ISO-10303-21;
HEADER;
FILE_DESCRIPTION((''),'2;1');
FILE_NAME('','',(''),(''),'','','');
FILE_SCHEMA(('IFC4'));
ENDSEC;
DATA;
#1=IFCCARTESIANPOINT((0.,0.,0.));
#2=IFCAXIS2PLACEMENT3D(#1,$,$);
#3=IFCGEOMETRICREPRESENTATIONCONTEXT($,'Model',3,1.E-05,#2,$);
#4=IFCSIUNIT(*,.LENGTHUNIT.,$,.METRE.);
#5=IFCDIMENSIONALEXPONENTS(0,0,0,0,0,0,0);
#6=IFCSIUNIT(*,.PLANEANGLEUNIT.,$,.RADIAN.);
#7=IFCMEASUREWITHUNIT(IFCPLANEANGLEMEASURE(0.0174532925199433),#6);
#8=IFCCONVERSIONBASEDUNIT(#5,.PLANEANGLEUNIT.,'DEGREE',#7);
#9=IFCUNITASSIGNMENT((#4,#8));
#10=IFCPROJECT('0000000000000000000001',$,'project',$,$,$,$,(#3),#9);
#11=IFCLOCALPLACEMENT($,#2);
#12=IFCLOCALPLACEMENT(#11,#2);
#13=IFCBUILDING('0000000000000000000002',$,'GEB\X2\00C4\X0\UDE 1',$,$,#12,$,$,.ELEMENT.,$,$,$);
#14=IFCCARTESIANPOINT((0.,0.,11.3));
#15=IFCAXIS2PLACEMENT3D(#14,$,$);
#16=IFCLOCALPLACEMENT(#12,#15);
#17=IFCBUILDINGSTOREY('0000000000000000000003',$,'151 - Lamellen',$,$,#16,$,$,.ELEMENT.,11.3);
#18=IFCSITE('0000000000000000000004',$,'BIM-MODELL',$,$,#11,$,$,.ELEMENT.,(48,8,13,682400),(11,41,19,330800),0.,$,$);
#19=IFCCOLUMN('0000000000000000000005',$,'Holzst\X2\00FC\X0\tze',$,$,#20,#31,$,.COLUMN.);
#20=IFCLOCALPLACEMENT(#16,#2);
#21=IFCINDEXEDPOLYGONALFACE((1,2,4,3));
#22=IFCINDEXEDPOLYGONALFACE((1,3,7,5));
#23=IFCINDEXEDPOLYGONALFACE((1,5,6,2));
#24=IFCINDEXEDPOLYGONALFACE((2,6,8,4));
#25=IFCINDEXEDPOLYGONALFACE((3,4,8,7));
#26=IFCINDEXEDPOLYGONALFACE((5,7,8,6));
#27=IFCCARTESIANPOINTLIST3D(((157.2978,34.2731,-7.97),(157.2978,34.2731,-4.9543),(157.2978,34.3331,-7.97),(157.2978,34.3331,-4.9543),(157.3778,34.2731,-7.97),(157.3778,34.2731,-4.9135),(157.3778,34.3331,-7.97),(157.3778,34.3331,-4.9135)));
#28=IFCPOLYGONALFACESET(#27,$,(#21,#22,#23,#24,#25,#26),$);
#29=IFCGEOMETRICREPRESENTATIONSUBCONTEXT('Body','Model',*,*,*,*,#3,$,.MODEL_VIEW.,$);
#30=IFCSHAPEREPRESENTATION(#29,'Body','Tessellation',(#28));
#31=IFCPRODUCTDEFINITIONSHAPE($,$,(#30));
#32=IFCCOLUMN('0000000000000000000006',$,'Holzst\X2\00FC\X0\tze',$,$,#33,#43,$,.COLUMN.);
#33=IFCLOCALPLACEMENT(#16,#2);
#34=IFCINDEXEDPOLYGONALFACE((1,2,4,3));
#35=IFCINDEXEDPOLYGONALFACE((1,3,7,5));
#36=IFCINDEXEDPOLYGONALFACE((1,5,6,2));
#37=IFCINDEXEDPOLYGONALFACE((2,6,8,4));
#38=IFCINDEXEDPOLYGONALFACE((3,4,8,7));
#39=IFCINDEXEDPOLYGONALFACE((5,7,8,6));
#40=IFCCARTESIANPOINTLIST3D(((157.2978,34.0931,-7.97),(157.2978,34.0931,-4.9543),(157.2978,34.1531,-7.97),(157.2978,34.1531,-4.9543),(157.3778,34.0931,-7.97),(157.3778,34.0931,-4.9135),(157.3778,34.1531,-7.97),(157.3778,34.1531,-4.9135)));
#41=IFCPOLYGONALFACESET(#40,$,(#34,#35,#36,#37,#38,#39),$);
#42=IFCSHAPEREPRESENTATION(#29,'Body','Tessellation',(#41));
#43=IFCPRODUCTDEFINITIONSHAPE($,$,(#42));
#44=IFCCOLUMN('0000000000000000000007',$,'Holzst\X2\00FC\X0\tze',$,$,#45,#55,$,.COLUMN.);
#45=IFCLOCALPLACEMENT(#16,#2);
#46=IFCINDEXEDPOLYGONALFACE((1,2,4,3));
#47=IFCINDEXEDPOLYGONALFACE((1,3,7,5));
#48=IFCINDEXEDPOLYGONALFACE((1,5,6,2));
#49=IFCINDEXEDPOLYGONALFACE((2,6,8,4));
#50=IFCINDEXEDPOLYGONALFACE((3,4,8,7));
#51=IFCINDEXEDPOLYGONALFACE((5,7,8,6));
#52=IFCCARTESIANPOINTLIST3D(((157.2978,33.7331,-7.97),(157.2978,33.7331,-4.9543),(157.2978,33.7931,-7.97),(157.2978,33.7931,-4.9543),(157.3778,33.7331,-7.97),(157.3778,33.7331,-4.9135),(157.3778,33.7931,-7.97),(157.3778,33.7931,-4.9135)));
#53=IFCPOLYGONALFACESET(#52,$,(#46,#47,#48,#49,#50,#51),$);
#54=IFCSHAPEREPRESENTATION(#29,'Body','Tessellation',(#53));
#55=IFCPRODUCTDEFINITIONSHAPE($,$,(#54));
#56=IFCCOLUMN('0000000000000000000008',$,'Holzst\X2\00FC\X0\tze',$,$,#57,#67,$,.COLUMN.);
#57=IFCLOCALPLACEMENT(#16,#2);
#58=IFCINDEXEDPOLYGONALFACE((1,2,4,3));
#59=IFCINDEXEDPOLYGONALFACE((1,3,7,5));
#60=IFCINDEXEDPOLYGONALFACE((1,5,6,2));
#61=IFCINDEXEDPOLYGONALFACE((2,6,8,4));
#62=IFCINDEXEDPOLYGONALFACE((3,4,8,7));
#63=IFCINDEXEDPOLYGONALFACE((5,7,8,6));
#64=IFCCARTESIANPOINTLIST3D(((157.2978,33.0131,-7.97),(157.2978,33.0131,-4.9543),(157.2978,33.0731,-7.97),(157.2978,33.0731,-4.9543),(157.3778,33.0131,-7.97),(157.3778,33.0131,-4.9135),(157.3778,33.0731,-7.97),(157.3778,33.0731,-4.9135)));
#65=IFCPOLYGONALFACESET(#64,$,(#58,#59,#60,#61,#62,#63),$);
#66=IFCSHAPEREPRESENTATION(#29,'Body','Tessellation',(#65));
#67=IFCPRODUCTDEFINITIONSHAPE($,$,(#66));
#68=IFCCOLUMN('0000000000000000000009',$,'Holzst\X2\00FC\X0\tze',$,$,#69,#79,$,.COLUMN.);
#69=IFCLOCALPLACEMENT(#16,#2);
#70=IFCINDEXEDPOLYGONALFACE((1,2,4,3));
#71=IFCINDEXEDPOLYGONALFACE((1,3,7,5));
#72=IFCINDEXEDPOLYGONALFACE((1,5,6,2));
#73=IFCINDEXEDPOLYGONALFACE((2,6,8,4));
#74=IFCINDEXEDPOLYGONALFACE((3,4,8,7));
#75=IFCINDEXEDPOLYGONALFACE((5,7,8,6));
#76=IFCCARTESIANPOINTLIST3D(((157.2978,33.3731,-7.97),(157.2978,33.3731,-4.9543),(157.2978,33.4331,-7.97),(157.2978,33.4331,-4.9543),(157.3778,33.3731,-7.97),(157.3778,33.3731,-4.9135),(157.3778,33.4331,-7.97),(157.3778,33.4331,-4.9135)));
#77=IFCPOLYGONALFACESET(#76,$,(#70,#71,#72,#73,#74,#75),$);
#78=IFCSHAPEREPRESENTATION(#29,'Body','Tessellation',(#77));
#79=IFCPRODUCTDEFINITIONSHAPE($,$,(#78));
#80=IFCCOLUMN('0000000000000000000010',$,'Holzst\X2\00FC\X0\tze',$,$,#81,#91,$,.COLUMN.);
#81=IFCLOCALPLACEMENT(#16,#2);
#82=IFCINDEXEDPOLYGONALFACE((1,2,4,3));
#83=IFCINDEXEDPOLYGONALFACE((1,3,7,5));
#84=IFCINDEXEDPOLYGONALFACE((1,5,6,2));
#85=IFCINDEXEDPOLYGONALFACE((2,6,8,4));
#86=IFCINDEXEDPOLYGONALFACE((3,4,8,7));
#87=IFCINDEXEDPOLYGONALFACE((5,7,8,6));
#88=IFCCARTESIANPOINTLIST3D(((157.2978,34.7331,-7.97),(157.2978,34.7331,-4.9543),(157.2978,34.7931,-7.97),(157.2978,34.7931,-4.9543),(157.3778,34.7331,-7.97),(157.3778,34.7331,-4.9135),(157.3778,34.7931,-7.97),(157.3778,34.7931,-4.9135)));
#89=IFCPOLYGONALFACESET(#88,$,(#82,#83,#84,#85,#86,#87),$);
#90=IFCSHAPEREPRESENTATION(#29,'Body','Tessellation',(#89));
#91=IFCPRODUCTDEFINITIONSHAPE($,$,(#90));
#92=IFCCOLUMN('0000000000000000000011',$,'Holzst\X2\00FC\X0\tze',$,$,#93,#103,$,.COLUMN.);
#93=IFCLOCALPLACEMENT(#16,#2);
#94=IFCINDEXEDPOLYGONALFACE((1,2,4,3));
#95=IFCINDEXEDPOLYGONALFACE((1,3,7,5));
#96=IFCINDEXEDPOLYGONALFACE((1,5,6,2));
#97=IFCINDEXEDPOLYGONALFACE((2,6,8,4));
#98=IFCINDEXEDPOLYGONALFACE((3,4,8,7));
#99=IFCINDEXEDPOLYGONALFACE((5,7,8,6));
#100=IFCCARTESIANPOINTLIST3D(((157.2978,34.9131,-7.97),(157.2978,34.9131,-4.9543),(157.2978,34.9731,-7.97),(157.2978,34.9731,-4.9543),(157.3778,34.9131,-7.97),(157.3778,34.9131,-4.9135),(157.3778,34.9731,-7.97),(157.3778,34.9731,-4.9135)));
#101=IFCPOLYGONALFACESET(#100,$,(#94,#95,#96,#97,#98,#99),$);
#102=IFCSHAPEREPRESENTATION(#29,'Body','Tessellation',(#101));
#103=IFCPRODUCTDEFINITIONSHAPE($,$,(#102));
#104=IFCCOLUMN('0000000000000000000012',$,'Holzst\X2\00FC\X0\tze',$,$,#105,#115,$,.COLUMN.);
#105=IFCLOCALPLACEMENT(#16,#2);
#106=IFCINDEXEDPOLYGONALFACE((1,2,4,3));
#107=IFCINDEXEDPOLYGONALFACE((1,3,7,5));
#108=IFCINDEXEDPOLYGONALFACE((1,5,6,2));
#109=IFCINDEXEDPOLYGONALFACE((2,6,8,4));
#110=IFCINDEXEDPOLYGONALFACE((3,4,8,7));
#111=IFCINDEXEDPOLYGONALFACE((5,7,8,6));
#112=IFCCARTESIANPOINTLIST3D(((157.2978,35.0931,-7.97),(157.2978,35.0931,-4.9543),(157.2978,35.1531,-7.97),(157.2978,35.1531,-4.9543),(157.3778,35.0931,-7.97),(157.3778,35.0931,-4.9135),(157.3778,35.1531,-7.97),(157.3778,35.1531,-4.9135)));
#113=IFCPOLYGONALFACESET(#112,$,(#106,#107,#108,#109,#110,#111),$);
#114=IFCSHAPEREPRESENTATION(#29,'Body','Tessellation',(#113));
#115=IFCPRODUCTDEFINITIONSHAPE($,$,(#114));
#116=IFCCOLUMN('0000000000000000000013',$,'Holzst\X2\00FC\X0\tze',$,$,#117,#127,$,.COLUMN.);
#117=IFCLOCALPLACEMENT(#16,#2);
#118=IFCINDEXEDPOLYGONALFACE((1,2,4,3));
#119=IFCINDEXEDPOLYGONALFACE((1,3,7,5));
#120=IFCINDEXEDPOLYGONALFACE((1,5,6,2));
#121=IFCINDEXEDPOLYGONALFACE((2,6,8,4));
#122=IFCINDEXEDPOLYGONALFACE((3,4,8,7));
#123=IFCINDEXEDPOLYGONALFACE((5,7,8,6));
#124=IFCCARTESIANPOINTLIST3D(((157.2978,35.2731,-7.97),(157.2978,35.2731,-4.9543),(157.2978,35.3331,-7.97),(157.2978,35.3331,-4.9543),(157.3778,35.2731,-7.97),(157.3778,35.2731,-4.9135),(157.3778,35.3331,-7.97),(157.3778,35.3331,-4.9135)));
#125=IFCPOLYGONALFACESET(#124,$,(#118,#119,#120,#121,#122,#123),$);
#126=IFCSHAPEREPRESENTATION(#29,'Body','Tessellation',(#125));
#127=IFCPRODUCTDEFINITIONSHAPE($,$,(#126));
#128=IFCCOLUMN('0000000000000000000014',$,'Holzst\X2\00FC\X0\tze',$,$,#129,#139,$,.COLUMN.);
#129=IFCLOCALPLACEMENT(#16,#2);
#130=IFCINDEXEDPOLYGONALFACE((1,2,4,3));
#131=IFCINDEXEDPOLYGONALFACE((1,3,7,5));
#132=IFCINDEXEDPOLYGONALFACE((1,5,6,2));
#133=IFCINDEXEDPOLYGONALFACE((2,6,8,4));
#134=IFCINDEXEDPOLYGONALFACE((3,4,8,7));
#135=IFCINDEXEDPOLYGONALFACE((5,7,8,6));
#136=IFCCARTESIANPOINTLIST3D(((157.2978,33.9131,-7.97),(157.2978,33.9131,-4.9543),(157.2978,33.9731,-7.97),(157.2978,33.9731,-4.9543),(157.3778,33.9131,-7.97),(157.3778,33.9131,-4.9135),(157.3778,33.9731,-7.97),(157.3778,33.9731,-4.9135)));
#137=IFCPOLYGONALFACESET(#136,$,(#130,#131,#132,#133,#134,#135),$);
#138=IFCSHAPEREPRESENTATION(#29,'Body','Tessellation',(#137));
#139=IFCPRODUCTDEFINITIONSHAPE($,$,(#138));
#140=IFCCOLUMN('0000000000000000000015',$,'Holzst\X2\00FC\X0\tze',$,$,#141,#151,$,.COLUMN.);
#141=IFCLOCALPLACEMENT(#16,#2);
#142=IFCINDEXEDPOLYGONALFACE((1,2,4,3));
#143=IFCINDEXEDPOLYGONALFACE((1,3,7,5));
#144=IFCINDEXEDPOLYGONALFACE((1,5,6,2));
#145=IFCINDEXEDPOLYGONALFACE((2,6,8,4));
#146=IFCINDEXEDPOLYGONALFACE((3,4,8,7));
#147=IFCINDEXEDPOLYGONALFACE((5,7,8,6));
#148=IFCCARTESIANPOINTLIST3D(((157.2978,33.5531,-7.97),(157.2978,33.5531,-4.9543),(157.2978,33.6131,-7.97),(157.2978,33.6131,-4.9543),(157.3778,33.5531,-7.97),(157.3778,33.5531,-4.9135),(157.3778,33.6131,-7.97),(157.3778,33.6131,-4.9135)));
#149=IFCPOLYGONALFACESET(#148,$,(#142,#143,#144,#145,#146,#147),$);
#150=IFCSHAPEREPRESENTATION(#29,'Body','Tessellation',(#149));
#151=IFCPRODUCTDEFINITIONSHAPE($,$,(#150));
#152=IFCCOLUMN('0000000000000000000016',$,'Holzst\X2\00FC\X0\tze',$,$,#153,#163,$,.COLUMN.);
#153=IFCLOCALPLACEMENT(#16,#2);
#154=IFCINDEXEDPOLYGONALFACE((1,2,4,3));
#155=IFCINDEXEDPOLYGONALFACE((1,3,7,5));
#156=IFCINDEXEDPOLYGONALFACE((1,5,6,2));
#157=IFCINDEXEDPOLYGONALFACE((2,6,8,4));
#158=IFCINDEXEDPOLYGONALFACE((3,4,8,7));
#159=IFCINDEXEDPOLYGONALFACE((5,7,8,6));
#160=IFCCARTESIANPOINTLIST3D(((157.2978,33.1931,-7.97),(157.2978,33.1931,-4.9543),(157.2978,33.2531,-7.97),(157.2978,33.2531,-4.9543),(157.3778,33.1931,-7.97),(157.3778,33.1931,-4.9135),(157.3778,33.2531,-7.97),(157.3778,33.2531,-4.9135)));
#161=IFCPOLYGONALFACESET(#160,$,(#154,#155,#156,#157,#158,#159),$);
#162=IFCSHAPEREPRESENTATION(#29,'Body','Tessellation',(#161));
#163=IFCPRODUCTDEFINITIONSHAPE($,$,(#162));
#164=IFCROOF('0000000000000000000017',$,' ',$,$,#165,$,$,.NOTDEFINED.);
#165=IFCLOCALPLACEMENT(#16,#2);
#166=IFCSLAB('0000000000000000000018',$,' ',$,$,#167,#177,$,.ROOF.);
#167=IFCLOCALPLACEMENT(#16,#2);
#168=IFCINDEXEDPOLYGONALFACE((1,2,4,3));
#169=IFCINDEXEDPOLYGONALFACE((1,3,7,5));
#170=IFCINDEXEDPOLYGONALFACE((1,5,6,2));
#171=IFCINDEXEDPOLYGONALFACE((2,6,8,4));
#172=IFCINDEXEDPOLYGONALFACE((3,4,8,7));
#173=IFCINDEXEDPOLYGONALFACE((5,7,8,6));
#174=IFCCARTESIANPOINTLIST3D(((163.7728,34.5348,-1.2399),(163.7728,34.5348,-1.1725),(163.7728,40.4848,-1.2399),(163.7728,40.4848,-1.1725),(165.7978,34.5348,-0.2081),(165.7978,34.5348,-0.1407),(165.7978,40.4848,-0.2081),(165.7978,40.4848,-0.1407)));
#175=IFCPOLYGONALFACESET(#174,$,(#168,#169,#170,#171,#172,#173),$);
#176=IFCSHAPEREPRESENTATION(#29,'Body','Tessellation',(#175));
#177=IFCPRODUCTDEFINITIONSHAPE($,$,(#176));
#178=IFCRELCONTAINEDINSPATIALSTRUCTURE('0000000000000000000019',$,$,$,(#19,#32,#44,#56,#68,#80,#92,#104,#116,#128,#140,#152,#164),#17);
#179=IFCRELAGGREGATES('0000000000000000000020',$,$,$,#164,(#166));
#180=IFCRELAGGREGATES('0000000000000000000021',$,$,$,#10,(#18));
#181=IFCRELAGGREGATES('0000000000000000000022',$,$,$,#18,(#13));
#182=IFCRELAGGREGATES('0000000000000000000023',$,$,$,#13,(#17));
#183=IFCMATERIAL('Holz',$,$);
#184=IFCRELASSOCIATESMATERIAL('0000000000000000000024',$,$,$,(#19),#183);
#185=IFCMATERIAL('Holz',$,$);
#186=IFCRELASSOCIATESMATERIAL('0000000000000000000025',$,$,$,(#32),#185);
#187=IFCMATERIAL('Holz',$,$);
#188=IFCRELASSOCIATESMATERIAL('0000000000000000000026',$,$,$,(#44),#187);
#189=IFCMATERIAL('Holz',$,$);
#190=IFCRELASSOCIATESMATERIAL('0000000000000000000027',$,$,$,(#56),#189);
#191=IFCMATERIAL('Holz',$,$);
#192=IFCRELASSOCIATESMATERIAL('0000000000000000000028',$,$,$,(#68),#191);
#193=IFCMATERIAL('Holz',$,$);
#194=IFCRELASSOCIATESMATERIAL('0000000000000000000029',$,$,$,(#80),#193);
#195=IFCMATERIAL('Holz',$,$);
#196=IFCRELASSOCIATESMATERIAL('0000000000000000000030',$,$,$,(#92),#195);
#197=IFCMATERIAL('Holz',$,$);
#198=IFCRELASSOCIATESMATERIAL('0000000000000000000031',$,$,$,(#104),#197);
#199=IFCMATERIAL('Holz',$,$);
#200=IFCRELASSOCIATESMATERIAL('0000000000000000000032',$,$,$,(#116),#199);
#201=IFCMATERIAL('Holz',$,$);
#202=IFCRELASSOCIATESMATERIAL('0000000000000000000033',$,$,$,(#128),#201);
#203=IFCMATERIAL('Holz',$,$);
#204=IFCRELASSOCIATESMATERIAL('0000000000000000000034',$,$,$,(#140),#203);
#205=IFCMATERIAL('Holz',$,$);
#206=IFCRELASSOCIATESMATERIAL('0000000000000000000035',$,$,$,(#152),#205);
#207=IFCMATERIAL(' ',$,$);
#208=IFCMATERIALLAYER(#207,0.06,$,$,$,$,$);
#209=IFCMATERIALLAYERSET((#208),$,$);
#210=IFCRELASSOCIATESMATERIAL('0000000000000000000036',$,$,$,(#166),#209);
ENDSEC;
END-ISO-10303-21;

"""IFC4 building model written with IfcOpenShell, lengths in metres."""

from ifc_helpers import new_model, entity, si_unit, converted_unit, frame, frame_2d, origin, origin_with_axes, origin_2d_with_axis, place, context, subcontext, project, spatial, rectangle, extrude, clip, halfspace, material, layer, layer_set, layer_usage, element, aggregate, save


model = new_model("IFC4")

# Units and contexts
model_context = context("Model", 3, precision=1e-05, world=origin())
body_context = subcontext(model_context, "Body", "Model", "MODEL_VIEW")
ifc_project = project(units=[si_unit("LENGTHUNIT", "METRE"), converted_unit("PLANEANGLEUNIT", "DEGREE", entity("IfcPlaneAngleMeasure", 0.0174532925199433), si_unit("PLANEANGLEUNIT", "RADIAN"), dimensions=[0, 0, 0, 0, 0, 0, 0])], contexts=[model_context])

# Site, building, storey
site_placement = place(None, origin())
site = spatial("IfcSite", under=ifc_project, at=site_placement, Name="BIM-MODELL", CompositionType="ELEMENT", RefLatitude=(48, 8, 13, 682400), RefLongitude=(11, 41, 19, 330800), RefElevation=0.0)
building_placement = place(site_placement, origin())
building = spatial("IfcBuilding", under=site, at=building_placement, Name="GEBÄUDE 1", CompositionType="ELEMENT")
storey_placement = place(building_placement, frame((0.0, 0.0, 11.3)))
storey = spatial("IfcBuildingStorey", under=building, at=storey_placement, Name="151 - Lamellen", CompositionType="ELEMENT", Elevation=11.3)

# Columns
ifc_material_1 = material(Name="Holz")
column_1_placement = place(storey_placement, frame((157.3778, 34.2731, -7.97)))
element("IfcColumn", 1, at=column_1_placement, inside=storey, material=ifc_material_1, Name="Holzstütze", PredefinedType="COLUMN", context=body_context, shape_type="Clipping", body=[
    clip(extrude(rectangle(XDim=0.06, YDim=0.08, at=frame_2d((-0.04, 0.03), x_axis=(0.0, 1.0))), origin_with_axes(), (0.0, 0.0, 1.0), 3.0565), halfspace(frame((-0.04, 0.03, 3.0361), z_axis=(0.45399, 0.0, -0.891007), x_axis=(-0.891007, 0.0, -0.45399)), True)),
])
ifc_material_2 = material(Name="Holz")
column_2_placement = place(storey_placement, frame((157.3778, 34.0931, -7.97)))
element("IfcColumn", 2, at=column_2_placement, inside=storey, material=ifc_material_2, Name="Holzstütze", PredefinedType="COLUMN", context=body_context, shape_type="Clipping", body=[
    clip(extrude(rectangle(XDim=0.06, YDim=0.08, at=frame_2d((-0.04, 0.03), x_axis=(0.0, 1.0))), origin_with_axes(), (0.0, 0.0, 1.0), 3.0565), halfspace(frame((-0.04, 0.03, 3.0361), z_axis=(0.45399, 0.0, -0.891007), x_axis=(-0.891007, 0.0, -0.45399)), True)),
])
ifc_material_3 = material(Name="Holz")
column_3_placement = place(storey_placement, frame((157.3778, 33.7331, -7.97)))
element("IfcColumn", 3, at=column_3_placement, inside=storey, material=ifc_material_3, Name="Holzstütze", PredefinedType="COLUMN", context=body_context, shape_type="Clipping", body=[
    clip(extrude(rectangle(XDim=0.06, YDim=0.08, at=frame_2d((-0.04, 0.03), x_axis=(0.0, 1.0))), origin_with_axes(), (0.0, 0.0, 1.0), 3.0565), halfspace(frame((-0.04, 0.03, 3.0361), z_axis=(0.45399, 0.0, -0.891007), x_axis=(-0.891007, 0.0, -0.45399)), True)),
])
ifc_material_4 = material(Name="Holz")
column_4_placement = place(storey_placement, frame((157.3778, 33.0131, -7.97)))
element("IfcColumn", 4, at=column_4_placement, inside=storey, material=ifc_material_4, Name="Holzstütze", PredefinedType="COLUMN", context=body_context, shape_type="Clipping", body=[
    clip(extrude(rectangle(XDim=0.06, YDim=0.08, at=frame_2d((-0.04, 0.03), x_axis=(0.0, 1.0))), origin_with_axes(), (0.0, 0.0, 1.0), 3.0565), halfspace(frame((-0.04, 0.03, 3.0361), z_axis=(0.45399, 0.0, -0.891007), x_axis=(-0.891007, 0.0, -0.45399)), True)),
])
ifc_material_5 = material(Name="Holz")
column_5_placement = place(storey_placement, frame((157.3778, 33.3731, -7.97)))
element("IfcColumn", 5, at=column_5_placement, inside=storey, material=ifc_material_5, Name="Holzstütze", PredefinedType="COLUMN", context=body_context, shape_type="Clipping", body=[
    clip(extrude(rectangle(XDim=0.06, YDim=0.08, at=frame_2d((-0.04, 0.03), x_axis=(0.0, 1.0))), origin_with_axes(), (0.0, 0.0, 1.0), 3.0565), halfspace(frame((-0.04, 0.03, 3.0361), z_axis=(0.45399, 0.0, -0.891007), x_axis=(-0.891007, 0.0, -0.45399)), True)),
])
ifc_material_6 = material(Name="Holz")
column_6_placement = place(storey_placement, frame((157.3778, 34.7331, -7.97)))
element("IfcColumn", 6, at=column_6_placement, inside=storey, material=ifc_material_6, Name="Holzstütze", PredefinedType="COLUMN", context=body_context, shape_type="Clipping", body=[
    clip(extrude(rectangle(XDim=0.06, YDim=0.08, at=frame_2d((-0.04, 0.03), x_axis=(0.0, 1.0))), origin_with_axes(), (0.0, 0.0, 1.0), 3.0565), halfspace(frame((-0.04, 0.03, 3.0361), z_axis=(0.45399, 0.0, -0.891007), x_axis=(-0.891007, 0.0, -0.45399)), True)),
])
ifc_material_7 = material(Name="Holz")
column_7_placement = place(storey_placement, frame((157.3778, 34.9131, -7.97)))
element("IfcColumn", 7, at=column_7_placement, inside=storey, material=ifc_material_7, Name="Holzstütze", PredefinedType="COLUMN", context=body_context, shape_type="Clipping", body=[
    clip(extrude(rectangle(XDim=0.06, YDim=0.08, at=frame_2d((-0.04, 0.03), x_axis=(0.0, 1.0))), origin_with_axes(), (0.0, 0.0, 1.0), 3.0565), halfspace(frame((-0.04, 0.03, 3.0361), z_axis=(0.45399, 0.0, -0.891007), x_axis=(-0.891007, 0.0, -0.45399)), True)),
])
ifc_material_8 = material(Name="Holz")
column_8_placement = place(storey_placement, frame((157.3778, 35.0931, -7.97)))
element("IfcColumn", 8, at=column_8_placement, inside=storey, material=ifc_material_8, Name="Holzstütze", PredefinedType="COLUMN", context=body_context, shape_type="Clipping", body=[
    clip(extrude(rectangle(XDim=0.06, YDim=0.08, at=frame_2d((-0.04, 0.03), x_axis=(0.0, 1.0))), origin_with_axes(), (0.0, 0.0, 1.0), 3.0565), halfspace(frame((-0.04, 0.03, 3.0361), z_axis=(0.45399, 0.0, -0.891007), x_axis=(-0.891007, 0.0, -0.45399)), True)),
])
ifc_material_9 = material(Name="Holz")
column_9_placement = place(storey_placement, frame((157.3778, 35.2731, -7.97)))
element("IfcColumn", 9, at=column_9_placement, inside=storey, material=ifc_material_9, Name="Holzstütze", PredefinedType="COLUMN", context=body_context, shape_type="Clipping", body=[
    clip(extrude(rectangle(XDim=0.06, YDim=0.08, at=frame_2d((-0.04, 0.03), x_axis=(0.0, 1.0))), origin_with_axes(), (0.0, 0.0, 1.0), 3.0565), halfspace(frame((-0.04, 0.03, 3.0361), z_axis=(0.45399, 0.0, -0.891007), x_axis=(-0.891007, 0.0, -0.45399)), True)),
])
ifc_material_10 = material(Name="Holz")
column_10_placement = place(storey_placement, frame((157.3778, 33.9131, -7.97)))
element("IfcColumn", 10, at=column_10_placement, inside=storey, material=ifc_material_10, Name="Holzstütze", PredefinedType="COLUMN", context=body_context, shape_type="Clipping", body=[
    clip(extrude(rectangle(XDim=0.06, YDim=0.08, at=frame_2d((-0.04, 0.03), x_axis=(0.0, 1.0))), origin_with_axes(), (0.0, 0.0, 1.0), 3.0565), halfspace(frame((-0.04, 0.03, 3.0361), z_axis=(0.45399, 0.0, -0.891007), x_axis=(-0.891007, 0.0, -0.45399)), True)),
])
ifc_material_11 = material(Name="Holz")
column_11_placement = place(storey_placement, frame((157.3778, 33.5531, -7.97)))
element("IfcColumn", 11, at=column_11_placement, inside=storey, material=ifc_material_11, Name="Holzstütze", PredefinedType="COLUMN", context=body_context, shape_type="Clipping", body=[
    clip(extrude(rectangle(XDim=0.06, YDim=0.08, at=frame_2d((-0.04, 0.03), x_axis=(0.0, 1.0))), origin_with_axes(), (0.0, 0.0, 1.0), 3.0565), halfspace(frame((-0.04, 0.03, 3.0361), z_axis=(0.45399, 0.0, -0.891007), x_axis=(-0.891007, 0.0, -0.45399)), True)),
])
ifc_material_12 = material(Name="Holz")
column_12_placement = place(storey_placement, frame((157.3778, 33.1931, -7.97)))
element("IfcColumn", 12, at=column_12_placement, inside=storey, material=ifc_material_12, Name="Holzstütze", PredefinedType="COLUMN", context=body_context, shape_type="Clipping", body=[
    clip(extrude(rectangle(XDim=0.06, YDim=0.08, at=frame_2d((-0.04, 0.03), x_axis=(0.0, 1.0))), origin_with_axes(), (0.0, 0.0, 1.0), 3.0565), halfspace(frame((-0.04, 0.03, 3.0361), z_axis=(0.45399, 0.0, -0.891007), x_axis=(-0.891007, 0.0, -0.45399)), True)),
])

# Roof, slab
roof_placement = place(storey_placement, frame((0.0, 0.0, -11.3)))
roof = element("IfcRoof", 13, at=roof_placement, inside=storey, Name=" ", PredefinedType="NOTDEFINED")
ifc_material_13 = material(Name=" ")
ifc_layer = layer(ifc_material_13, 0.06)
ifc_layer_set = layer_set([ifc_layer])
ifc_layer_usage = layer_usage(ifc_layer_set, "AXIS3", "POSITIVE", 0.0)
slab_placement = place(roof_placement, frame((163.7728, 34.5348, 10.0601)))
slab = element("IfcSlab", 14, at=slab_placement, material=ifc_layer_usage, Name=" ", PredefinedType="ROOF", context=body_context, shape_type="SweptSolid", body=[
    extrude(rectangle(XDim=5.95, YDim=2.2727, at=origin_2d_with_axis()), frame((1.0125, 2.975, 0.5159), z_axis=(-0.45399, 0.0, 0.891007), x_axis=(0.0, 1.0, 0.0)), (0.0, -0.45399, 0.891007), 0.0673),
])
aggregate(roof, [slab])

save(model, "model.ifc")
